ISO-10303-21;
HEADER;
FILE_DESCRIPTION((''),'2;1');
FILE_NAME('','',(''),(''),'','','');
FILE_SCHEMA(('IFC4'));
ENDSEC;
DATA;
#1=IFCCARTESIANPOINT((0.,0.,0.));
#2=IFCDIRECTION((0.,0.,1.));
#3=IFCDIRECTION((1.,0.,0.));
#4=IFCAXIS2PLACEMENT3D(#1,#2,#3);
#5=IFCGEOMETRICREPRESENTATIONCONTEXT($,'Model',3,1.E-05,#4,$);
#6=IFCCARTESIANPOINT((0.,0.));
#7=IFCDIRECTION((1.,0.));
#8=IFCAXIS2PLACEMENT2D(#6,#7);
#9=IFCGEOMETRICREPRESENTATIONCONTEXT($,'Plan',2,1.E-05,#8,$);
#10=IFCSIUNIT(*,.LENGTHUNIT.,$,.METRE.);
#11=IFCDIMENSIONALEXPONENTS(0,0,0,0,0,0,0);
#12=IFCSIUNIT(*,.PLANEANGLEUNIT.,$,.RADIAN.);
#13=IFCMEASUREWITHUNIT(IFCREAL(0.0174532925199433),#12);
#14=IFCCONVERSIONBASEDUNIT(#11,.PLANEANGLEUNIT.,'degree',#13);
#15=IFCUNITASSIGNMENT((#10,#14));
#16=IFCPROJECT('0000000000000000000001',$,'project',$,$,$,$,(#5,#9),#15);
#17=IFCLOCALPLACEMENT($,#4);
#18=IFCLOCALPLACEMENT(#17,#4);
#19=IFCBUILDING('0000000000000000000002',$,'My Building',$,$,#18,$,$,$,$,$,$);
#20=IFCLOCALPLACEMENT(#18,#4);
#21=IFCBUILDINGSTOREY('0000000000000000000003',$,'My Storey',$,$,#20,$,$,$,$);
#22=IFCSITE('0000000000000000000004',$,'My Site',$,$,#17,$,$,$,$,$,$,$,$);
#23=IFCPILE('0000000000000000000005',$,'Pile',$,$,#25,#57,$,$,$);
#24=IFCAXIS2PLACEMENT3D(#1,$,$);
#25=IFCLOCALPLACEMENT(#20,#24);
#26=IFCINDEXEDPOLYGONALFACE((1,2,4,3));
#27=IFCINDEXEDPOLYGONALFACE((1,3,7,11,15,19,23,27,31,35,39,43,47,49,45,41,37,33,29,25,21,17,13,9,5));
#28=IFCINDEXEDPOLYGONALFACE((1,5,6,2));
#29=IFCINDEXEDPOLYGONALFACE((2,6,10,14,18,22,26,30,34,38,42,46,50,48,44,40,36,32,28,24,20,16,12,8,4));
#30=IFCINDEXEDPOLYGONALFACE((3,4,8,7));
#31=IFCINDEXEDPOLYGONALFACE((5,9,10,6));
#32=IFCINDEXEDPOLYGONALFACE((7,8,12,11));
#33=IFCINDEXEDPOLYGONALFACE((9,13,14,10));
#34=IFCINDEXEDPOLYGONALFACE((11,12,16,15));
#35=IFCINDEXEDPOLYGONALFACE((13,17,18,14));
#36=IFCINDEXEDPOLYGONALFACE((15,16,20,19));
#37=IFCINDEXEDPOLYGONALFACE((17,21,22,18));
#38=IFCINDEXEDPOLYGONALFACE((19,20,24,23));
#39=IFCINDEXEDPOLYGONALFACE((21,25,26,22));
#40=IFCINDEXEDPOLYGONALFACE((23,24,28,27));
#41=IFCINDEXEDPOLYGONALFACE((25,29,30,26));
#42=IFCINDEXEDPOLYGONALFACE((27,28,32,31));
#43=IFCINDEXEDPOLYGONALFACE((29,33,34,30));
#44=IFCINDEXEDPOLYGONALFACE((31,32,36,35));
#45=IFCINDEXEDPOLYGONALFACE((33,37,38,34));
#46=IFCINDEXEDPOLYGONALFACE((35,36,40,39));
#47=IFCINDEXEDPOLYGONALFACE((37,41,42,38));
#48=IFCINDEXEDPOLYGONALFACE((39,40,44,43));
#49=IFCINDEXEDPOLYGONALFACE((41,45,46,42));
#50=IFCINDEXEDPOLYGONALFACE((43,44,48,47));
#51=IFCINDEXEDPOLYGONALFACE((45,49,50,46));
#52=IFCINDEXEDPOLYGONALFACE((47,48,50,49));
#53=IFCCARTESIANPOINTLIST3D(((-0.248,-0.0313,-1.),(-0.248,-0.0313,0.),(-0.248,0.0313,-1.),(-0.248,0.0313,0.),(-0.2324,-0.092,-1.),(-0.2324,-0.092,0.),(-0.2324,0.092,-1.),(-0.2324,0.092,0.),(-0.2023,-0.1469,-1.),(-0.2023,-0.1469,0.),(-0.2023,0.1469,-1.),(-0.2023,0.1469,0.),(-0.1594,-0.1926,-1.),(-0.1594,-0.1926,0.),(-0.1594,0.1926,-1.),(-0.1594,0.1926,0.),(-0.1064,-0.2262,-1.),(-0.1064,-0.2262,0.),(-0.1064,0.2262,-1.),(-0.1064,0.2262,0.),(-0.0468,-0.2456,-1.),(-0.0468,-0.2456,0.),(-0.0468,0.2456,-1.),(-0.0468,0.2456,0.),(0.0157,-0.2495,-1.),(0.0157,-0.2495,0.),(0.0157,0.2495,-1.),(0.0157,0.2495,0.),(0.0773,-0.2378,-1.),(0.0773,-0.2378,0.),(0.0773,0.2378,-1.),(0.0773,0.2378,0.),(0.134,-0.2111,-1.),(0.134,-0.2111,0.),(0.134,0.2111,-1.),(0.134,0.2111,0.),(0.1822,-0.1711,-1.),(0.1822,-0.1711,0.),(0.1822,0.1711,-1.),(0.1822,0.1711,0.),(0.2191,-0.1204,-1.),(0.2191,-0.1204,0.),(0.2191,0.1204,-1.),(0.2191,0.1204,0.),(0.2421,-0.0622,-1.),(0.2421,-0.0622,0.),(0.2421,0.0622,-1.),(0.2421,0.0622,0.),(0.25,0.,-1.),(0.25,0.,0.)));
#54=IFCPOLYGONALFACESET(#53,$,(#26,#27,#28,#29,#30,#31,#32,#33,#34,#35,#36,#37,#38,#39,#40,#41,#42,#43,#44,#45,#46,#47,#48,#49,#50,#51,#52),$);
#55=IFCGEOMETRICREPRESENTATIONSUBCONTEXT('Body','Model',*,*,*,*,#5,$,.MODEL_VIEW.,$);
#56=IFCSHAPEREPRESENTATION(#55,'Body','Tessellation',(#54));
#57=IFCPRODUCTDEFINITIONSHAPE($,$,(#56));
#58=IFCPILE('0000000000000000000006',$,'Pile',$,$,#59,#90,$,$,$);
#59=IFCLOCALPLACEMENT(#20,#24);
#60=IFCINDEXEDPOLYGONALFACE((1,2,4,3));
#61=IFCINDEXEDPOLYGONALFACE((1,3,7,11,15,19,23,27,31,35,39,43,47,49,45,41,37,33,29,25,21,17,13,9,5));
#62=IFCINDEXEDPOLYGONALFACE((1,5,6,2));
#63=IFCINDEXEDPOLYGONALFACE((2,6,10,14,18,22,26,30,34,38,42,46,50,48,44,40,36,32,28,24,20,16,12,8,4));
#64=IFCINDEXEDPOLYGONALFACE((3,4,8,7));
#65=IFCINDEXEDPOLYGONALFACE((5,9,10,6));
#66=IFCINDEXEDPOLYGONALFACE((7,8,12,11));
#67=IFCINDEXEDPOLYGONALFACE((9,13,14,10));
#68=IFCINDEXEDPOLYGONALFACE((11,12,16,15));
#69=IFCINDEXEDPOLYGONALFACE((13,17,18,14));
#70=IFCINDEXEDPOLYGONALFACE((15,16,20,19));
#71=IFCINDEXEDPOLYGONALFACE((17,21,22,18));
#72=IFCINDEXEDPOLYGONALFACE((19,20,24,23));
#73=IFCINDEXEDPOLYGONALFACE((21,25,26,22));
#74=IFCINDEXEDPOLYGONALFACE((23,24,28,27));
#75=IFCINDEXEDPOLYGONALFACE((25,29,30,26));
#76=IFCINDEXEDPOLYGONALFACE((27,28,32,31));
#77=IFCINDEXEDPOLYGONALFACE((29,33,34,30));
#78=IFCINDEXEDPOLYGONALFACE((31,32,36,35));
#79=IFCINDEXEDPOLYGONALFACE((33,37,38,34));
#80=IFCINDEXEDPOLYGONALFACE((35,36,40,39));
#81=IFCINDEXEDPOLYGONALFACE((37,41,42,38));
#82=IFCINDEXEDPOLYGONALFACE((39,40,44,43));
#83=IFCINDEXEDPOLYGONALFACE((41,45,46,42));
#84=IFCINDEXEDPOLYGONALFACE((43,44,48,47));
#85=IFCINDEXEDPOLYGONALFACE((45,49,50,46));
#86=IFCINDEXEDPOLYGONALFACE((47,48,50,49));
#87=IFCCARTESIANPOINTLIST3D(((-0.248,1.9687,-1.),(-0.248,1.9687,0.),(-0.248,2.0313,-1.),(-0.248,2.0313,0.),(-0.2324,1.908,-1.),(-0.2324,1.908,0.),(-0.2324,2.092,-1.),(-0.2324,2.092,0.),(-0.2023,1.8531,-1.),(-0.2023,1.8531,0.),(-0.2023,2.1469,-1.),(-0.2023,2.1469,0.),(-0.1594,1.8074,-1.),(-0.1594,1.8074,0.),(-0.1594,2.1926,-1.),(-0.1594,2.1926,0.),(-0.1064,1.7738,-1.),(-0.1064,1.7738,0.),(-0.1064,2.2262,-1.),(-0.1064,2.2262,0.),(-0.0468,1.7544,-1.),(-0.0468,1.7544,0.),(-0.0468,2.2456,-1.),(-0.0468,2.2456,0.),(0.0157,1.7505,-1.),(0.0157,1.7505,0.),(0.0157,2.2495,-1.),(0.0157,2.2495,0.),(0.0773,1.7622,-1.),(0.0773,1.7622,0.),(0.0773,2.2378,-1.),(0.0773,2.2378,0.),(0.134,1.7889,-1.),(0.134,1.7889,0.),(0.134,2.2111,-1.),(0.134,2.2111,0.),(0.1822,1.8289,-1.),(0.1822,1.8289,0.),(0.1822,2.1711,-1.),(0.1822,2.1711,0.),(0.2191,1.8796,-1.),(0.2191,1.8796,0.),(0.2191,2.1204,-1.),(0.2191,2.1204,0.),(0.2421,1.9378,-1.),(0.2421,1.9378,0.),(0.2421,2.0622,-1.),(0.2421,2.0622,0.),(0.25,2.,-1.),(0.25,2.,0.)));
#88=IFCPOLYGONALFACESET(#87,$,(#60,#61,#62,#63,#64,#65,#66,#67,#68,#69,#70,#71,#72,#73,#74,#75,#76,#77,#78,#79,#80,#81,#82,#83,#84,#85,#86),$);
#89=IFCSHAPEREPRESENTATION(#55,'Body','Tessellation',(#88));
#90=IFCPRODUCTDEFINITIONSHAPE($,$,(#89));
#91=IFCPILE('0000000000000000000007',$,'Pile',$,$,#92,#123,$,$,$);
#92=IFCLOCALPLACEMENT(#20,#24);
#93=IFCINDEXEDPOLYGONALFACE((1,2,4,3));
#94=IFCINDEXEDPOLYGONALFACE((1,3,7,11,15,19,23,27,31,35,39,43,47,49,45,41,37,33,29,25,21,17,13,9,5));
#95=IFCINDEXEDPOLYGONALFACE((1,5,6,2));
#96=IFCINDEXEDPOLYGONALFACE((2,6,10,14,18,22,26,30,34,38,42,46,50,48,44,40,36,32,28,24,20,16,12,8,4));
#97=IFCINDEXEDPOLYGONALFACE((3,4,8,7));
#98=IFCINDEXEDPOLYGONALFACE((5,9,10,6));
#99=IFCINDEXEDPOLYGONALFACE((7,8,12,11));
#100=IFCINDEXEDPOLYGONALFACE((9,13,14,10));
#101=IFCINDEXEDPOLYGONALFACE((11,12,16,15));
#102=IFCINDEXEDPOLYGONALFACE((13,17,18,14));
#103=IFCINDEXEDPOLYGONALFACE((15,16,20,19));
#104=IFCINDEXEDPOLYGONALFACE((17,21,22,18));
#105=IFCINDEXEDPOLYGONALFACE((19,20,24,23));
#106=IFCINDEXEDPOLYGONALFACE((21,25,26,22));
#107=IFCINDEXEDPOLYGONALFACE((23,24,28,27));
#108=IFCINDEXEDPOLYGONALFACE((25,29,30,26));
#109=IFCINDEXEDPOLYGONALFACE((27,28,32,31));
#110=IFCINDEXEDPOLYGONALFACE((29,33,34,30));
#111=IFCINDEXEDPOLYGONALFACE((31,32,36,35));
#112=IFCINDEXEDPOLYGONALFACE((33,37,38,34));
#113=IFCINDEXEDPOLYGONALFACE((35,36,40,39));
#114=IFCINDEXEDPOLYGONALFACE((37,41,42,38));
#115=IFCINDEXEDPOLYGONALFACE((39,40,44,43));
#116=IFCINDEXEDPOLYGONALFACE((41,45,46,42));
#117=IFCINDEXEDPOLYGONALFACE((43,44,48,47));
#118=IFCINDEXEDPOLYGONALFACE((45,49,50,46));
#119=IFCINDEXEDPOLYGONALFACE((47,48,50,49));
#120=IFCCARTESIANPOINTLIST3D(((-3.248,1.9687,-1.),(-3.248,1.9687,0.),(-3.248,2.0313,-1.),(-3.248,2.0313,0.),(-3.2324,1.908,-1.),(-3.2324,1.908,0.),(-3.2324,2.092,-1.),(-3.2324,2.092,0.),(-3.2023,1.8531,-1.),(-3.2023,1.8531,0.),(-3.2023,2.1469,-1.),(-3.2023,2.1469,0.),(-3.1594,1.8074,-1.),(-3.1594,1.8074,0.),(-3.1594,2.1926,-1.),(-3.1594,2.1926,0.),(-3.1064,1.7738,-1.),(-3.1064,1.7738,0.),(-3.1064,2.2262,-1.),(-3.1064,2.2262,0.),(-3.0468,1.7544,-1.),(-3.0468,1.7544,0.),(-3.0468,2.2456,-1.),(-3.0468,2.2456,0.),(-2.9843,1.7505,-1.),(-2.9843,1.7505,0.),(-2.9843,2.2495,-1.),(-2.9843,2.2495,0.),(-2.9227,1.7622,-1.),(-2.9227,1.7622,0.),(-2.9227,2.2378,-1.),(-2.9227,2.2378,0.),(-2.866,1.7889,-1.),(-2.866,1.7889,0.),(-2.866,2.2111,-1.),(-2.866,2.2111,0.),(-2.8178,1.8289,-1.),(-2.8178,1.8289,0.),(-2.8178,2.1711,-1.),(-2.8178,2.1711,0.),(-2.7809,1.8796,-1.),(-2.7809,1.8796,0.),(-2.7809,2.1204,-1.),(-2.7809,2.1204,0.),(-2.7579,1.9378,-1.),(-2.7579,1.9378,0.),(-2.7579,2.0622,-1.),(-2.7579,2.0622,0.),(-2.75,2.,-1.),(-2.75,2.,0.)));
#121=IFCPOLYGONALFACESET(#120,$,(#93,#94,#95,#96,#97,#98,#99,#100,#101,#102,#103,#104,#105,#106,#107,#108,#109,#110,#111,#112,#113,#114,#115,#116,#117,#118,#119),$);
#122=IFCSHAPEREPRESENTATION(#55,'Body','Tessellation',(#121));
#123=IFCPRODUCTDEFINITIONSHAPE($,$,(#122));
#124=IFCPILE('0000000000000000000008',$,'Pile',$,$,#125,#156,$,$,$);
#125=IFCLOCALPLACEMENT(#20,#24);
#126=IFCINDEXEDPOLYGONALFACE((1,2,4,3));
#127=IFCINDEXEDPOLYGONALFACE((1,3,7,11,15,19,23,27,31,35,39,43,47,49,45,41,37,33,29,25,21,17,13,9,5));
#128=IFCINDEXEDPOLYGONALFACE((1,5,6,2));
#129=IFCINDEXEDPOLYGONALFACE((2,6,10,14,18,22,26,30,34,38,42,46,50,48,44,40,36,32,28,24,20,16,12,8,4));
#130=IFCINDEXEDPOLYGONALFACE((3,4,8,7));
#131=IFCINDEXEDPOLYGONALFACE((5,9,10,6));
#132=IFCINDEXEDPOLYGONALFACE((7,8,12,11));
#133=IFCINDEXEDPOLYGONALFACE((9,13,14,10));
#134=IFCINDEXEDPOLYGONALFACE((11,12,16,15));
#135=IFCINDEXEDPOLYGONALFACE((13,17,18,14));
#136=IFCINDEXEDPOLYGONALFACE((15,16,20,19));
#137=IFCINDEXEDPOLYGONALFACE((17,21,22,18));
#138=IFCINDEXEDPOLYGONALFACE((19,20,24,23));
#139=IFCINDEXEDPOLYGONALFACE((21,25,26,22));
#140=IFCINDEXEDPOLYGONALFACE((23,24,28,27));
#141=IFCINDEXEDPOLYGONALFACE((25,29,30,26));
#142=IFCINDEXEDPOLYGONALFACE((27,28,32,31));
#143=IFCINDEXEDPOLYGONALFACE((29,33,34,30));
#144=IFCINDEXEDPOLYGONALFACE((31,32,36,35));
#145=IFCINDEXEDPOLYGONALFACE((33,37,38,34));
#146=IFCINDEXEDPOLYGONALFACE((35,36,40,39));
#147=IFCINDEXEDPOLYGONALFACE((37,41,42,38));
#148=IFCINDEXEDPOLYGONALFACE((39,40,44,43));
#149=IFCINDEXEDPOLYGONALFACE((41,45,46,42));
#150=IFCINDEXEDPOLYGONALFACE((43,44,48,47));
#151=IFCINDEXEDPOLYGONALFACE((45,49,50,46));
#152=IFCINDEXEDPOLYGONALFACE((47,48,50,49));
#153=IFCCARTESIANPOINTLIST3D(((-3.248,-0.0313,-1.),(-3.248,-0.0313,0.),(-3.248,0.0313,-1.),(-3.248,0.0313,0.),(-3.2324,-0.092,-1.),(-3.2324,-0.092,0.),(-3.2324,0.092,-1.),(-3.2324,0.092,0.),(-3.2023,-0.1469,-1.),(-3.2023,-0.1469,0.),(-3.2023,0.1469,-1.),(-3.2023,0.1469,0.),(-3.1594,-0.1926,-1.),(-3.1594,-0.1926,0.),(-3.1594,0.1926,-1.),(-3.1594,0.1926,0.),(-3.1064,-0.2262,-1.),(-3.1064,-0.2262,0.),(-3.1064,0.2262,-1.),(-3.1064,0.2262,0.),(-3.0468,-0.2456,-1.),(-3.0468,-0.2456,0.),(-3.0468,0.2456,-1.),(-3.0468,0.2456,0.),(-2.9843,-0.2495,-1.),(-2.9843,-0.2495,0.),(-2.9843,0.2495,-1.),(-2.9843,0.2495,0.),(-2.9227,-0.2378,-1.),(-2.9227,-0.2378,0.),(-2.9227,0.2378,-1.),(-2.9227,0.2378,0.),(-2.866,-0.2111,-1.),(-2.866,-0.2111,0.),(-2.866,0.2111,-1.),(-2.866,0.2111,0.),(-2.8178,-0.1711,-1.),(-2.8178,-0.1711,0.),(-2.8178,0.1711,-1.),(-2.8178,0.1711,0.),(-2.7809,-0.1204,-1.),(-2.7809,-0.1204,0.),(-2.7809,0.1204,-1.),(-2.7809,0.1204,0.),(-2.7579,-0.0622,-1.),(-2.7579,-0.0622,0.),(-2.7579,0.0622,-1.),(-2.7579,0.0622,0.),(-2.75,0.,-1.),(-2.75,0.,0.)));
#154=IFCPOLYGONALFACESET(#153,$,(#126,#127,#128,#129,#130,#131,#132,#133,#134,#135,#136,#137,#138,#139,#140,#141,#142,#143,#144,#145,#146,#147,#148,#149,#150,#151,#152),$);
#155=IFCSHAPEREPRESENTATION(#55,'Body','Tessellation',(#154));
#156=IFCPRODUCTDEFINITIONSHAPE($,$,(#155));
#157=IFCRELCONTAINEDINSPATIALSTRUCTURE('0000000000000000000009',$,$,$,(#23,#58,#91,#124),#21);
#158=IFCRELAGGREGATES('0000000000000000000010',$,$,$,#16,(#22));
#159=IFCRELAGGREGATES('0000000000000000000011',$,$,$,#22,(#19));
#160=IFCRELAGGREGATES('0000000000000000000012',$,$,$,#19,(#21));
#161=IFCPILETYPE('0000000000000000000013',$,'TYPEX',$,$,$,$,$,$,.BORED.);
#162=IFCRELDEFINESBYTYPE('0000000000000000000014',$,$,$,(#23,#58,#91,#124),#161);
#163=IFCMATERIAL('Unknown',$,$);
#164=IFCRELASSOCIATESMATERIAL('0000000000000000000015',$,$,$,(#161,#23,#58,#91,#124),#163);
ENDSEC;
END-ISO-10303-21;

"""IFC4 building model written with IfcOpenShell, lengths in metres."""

from ifc_helpers import new_model, entity, si_unit, converted_unit, frame, origin_with_axes, origin_2d_with_axis, place, context, subcontext, project, spatial, circle, extrude, material, material_profile, profile_set, profile_usage, type_object, element, save


model = new_model("IFC4")

# Units and contexts
model_context = context("Model", 3, precision=1e-05, world=origin_with_axes())
plan_context = context("Plan", 2, precision=1e-05, world=origin_2d_with_axis())
body_context = subcontext(model_context, "Body", "Model", "MODEL_VIEW")
ifc_project = project(units=[si_unit("LENGTHUNIT", "METRE"), converted_unit("PLANEANGLEUNIT", "degree", entity("IfcReal", 0.0174532925199433), si_unit("PLANEANGLEUNIT", "RADIAN"), dimensions=[0, 0, 0, 0, 0, 0, 0])], contexts=[model_context, plan_context])

# Site, building, storey
site_placement = place(None, origin_with_axes())
site = spatial("IfcSite", under=ifc_project, at=site_placement, Name="My Site")
building_placement = place(site_placement, origin_with_axes())
building = spatial("IfcBuilding", under=site, at=building_placement, Name="My Building")
storey_placement = place(building_placement, origin_with_axes())
storey = spatial("IfcBuildingStorey", under=building, at=storey_placement, Name="My Storey")

# Piles
ifc_material = material(Name="Unknown")
ifc_material_profile_1 = material_profile(ifc_material, circle(Radius=0.25))
ifc_profile_set_1 = profile_set([ifc_material_profile_1], Name="Pile foundation")
ifc_profile_usage_1 = profile_usage(ifc_profile_set_1, cardinal=5)
pile_type = type_object("IfcPileType", Name="TYPEX", PredefinedType="BORED", material=ifc_profile_set_1)
pile_1_placement = place(storey_placement, frame((0.0, 0.0, -1.0), z_axis=(0.0, 0.0, 1.0), x_axis=(1.0, 0.0, 0.0)))
element("IfcPile", 1, at=pile_1_placement, inside=storey, type_object=pile_type, material=ifc_profile_usage_1, Name="Pile", context=body_context, shape_type="SweptSolid", body=[
    extrude(circle(Radius=0.25), origin_with_axes(), (0.0, 0.0, 1.0), 1.0),
])
ifc_profile_usage_2 = profile_usage(ifc_profile_set_1, cardinal=5)
pile_2_placement = place(storey_placement, frame((0.0, 2.0, -1.0), z_axis=(0.0, 0.0, 1.0), x_axis=(1.0, 0.0, 0.0)))
element("IfcPile", 2, at=pile_2_placement, inside=storey, type_object=pile_type, material=ifc_profile_usage_2, Name="Pile", context=body_context, shape_type="SweptSolid", body=[
    extrude(circle(Radius=0.25), origin_with_axes(), (0.0, 0.0, 1.0), 1.0),
])
ifc_profile_usage_3 = profile_usage(ifc_profile_set_1, cardinal=5)
pile_3_placement = place(storey_placement, frame((-3.0, 2.0, -1.0), z_axis=(0.0, 0.0, 1.0), x_axis=(1.0, 0.0, 0.0)))
element("IfcPile", 3, at=pile_3_placement, inside=storey, type_object=pile_type, material=ifc_profile_usage_3, Name="Pile", context=body_context, shape_type="SweptSolid", body=[
    extrude(circle(Radius=0.25), origin_with_axes(), (0.0, 0.0, 1.0), 1.0),
])
ifc_profile_usage_4 = profile_usage(ifc_profile_set_1, cardinal=5)
pile_4_placement = place(storey_placement, frame((-3.0, 0.0, -1.0), z_axis=(0.0, 0.0, 1.0), x_axis=(1.0, 0.0, 0.0)))
element("IfcPile", 4, at=pile_4_placement, inside=storey, type_object=pile_type, material=ifc_profile_usage_4, Name="Pile", context=body_context, shape_type="SweptSolid", body=[
    extrude(circle(Radius=0.25), origin_with_axes(), (0.0, 0.0, 1.0), 1.0),
])

save(model, "model.ifc")
